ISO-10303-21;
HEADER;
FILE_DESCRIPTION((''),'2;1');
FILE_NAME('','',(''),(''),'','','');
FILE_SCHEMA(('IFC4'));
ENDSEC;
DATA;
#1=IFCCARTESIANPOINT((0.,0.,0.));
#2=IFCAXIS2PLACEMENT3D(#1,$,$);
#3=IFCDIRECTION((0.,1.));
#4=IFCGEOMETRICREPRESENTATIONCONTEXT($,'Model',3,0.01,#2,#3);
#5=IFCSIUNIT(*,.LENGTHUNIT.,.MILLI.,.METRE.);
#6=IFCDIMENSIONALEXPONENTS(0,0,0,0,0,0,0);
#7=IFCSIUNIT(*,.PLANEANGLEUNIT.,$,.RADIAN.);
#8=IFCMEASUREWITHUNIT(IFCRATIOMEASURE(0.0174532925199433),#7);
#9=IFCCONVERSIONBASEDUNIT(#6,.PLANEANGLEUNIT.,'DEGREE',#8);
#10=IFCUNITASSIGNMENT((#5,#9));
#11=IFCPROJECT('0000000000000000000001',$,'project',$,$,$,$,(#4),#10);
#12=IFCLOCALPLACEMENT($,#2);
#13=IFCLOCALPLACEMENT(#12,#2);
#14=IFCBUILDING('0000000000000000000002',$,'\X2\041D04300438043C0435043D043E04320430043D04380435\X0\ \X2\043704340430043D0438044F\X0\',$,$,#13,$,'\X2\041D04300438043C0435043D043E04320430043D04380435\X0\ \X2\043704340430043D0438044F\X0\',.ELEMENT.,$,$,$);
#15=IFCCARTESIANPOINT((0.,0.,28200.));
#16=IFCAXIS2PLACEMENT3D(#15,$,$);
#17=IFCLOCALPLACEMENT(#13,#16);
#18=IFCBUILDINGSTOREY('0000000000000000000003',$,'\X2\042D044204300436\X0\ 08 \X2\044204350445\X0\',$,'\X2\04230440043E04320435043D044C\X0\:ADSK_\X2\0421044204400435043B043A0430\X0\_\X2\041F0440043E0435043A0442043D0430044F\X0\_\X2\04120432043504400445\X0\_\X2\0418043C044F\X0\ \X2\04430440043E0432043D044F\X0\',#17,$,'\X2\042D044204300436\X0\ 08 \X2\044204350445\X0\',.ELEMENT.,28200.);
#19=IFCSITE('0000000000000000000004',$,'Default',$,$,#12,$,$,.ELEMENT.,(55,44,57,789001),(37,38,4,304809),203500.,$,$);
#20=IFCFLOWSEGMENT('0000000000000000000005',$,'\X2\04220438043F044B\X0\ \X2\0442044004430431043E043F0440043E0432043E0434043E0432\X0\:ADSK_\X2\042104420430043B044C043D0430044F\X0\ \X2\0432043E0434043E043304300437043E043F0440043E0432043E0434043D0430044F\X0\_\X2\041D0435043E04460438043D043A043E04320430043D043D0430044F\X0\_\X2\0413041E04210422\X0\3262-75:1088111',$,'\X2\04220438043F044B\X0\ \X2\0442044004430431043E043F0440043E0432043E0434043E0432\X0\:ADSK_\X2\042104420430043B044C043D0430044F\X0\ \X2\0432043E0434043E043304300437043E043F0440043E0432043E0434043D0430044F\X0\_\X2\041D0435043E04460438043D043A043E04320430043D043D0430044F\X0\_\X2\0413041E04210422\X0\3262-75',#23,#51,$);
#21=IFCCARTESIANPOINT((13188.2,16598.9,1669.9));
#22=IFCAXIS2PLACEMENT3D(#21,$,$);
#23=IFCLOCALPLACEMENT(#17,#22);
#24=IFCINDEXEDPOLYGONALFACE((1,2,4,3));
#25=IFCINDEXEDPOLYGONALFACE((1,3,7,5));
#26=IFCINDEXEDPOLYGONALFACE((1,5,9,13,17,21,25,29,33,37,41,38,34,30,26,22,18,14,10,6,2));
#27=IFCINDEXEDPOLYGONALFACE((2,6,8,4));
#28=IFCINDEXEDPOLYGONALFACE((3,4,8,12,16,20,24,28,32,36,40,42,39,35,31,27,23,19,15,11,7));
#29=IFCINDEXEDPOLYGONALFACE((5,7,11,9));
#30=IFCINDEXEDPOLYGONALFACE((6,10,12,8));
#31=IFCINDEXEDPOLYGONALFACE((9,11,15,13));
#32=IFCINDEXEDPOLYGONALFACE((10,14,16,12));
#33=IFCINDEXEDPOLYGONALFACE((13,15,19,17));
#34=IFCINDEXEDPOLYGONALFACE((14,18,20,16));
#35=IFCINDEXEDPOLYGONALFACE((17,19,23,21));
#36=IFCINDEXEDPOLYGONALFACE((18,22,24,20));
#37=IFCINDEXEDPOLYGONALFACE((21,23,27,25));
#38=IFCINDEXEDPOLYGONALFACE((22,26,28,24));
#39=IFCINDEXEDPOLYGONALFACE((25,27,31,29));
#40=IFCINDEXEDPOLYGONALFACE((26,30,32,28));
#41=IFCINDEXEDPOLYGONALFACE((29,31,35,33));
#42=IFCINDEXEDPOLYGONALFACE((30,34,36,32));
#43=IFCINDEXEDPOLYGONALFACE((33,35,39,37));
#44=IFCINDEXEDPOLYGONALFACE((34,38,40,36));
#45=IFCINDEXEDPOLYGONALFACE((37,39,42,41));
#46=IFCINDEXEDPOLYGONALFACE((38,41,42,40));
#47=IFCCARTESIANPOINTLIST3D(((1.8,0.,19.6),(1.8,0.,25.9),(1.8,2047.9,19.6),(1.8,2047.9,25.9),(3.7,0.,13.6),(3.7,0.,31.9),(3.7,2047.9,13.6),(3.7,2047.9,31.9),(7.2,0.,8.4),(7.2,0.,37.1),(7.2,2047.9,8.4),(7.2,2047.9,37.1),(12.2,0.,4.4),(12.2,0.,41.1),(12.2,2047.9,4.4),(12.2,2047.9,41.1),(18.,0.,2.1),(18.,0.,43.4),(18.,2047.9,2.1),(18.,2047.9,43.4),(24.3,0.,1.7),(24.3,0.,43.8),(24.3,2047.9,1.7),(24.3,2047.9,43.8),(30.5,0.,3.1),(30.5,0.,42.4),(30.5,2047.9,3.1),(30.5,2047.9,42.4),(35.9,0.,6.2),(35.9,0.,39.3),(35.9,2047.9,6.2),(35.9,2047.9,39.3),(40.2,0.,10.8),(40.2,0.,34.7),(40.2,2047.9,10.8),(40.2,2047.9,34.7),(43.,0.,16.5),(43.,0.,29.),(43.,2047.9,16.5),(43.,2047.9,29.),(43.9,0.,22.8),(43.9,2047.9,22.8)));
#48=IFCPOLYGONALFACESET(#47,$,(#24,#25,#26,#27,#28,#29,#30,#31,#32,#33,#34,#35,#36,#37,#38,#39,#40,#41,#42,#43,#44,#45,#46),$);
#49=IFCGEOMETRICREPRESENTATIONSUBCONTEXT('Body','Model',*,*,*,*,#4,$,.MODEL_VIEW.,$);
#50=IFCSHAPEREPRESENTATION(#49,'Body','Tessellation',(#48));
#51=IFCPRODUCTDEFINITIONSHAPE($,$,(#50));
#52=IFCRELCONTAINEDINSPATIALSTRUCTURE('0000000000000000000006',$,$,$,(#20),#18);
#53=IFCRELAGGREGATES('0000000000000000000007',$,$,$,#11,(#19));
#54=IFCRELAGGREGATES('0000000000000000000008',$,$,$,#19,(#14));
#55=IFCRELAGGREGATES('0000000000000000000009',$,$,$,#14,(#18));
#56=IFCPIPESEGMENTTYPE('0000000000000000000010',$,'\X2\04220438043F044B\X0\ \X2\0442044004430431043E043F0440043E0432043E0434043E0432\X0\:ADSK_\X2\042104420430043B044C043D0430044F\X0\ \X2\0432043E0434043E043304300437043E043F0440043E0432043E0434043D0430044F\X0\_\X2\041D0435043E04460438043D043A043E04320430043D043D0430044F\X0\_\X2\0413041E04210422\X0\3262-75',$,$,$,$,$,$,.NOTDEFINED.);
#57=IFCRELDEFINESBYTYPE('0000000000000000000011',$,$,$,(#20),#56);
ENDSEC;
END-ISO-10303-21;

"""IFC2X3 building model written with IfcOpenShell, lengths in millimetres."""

from ifc_helpers import new_model, entity, si_unit, converted_unit, direction, frame, origin, origin_2d_with_axis, place, context, subcontext, project, spatial, circle, extrude, type_object, element, save


model = new_model("IFC2X3")

# Units and contexts
model_context = context("Model", 3, precision=0.01, world=origin(), true_north=direction((0.0, 1.0)))
body_context = subcontext(model_context, "Body", "Model", "MODEL_VIEW")
ifc_project = project(units=[si_unit("LENGTHUNIT", "METRE", prefix="MILLI"), converted_unit("PLANEANGLEUNIT", "DEGREE", entity("IfcRatioMeasure", 0.0174532925199433), si_unit("PLANEANGLEUNIT", "RADIAN"), dimensions=[0, 0, 0, 0, 0, 0, 0])], contexts=[model_context])

# Site, building, storey
site_placement = place(None, origin())
site = spatial("IfcSite", under=ifc_project, at=site_placement, Name="Default", CompositionType="ELEMENT", RefLatitude=(55, 44, 57, 789001), RefLongitude=(37, 38, 4, 304809), RefElevation=203500.0)
building_placement = place(site_placement, origin())
building = spatial("IfcBuilding", under=site, at=building_placement, Name="Наименование здания", LongName="Наименование здания", CompositionType="ELEMENT")
storey_placement = place(building_placement, frame((0.0, 0.0, 28200.0)))
storey = spatial("IfcBuildingStorey", under=building, at=storey_placement, Name="Этаж 08 тех", ObjectType="Уровень:ADSK_Стрелка_Проектная_Вверх_Имя уровня", LongName="Этаж 08 тех", CompositionType="ELEMENT", Elevation=28200.0)

# Flow segment
pipe_segment_type = type_object("IfcPipeSegmentType", Name="Типы трубопроводов:ADSK_Стальная водогазопроводная_Неоцинкованная_ГОСТ3262-75", PredefinedType="NOTDEFINED")
flow_segment_1_placement = place(storey_placement, frame((13188.2, 16598.9, 1669.9)))
element("IfcFlowSegment", 1, at=flow_segment_1_placement, inside=storey, type_object=pipe_segment_type, Name="Типы трубопроводов:ADSK_Стальная водогазопроводная_Неоцинкованная_ГОСТ3262-75:1088111", ObjectType="Типы трубопроводов:ADSK_Стальная водогазопроводная_Неоцинкованная_ГОСТ3262-75", context=body_context, shape_type="SweptSolid", body=[
    extrude(circle(Radius=21.1, at=origin_2d_with_axis()), frame((22.8, 0.0, 22.8), z_axis=(0.0, 1.0, 0.0), x_axis=(1.0, 0.0, 0.0)), (0.0, 0.0, 1.0), 2047.9),
])

save(model, "model.ifc")
